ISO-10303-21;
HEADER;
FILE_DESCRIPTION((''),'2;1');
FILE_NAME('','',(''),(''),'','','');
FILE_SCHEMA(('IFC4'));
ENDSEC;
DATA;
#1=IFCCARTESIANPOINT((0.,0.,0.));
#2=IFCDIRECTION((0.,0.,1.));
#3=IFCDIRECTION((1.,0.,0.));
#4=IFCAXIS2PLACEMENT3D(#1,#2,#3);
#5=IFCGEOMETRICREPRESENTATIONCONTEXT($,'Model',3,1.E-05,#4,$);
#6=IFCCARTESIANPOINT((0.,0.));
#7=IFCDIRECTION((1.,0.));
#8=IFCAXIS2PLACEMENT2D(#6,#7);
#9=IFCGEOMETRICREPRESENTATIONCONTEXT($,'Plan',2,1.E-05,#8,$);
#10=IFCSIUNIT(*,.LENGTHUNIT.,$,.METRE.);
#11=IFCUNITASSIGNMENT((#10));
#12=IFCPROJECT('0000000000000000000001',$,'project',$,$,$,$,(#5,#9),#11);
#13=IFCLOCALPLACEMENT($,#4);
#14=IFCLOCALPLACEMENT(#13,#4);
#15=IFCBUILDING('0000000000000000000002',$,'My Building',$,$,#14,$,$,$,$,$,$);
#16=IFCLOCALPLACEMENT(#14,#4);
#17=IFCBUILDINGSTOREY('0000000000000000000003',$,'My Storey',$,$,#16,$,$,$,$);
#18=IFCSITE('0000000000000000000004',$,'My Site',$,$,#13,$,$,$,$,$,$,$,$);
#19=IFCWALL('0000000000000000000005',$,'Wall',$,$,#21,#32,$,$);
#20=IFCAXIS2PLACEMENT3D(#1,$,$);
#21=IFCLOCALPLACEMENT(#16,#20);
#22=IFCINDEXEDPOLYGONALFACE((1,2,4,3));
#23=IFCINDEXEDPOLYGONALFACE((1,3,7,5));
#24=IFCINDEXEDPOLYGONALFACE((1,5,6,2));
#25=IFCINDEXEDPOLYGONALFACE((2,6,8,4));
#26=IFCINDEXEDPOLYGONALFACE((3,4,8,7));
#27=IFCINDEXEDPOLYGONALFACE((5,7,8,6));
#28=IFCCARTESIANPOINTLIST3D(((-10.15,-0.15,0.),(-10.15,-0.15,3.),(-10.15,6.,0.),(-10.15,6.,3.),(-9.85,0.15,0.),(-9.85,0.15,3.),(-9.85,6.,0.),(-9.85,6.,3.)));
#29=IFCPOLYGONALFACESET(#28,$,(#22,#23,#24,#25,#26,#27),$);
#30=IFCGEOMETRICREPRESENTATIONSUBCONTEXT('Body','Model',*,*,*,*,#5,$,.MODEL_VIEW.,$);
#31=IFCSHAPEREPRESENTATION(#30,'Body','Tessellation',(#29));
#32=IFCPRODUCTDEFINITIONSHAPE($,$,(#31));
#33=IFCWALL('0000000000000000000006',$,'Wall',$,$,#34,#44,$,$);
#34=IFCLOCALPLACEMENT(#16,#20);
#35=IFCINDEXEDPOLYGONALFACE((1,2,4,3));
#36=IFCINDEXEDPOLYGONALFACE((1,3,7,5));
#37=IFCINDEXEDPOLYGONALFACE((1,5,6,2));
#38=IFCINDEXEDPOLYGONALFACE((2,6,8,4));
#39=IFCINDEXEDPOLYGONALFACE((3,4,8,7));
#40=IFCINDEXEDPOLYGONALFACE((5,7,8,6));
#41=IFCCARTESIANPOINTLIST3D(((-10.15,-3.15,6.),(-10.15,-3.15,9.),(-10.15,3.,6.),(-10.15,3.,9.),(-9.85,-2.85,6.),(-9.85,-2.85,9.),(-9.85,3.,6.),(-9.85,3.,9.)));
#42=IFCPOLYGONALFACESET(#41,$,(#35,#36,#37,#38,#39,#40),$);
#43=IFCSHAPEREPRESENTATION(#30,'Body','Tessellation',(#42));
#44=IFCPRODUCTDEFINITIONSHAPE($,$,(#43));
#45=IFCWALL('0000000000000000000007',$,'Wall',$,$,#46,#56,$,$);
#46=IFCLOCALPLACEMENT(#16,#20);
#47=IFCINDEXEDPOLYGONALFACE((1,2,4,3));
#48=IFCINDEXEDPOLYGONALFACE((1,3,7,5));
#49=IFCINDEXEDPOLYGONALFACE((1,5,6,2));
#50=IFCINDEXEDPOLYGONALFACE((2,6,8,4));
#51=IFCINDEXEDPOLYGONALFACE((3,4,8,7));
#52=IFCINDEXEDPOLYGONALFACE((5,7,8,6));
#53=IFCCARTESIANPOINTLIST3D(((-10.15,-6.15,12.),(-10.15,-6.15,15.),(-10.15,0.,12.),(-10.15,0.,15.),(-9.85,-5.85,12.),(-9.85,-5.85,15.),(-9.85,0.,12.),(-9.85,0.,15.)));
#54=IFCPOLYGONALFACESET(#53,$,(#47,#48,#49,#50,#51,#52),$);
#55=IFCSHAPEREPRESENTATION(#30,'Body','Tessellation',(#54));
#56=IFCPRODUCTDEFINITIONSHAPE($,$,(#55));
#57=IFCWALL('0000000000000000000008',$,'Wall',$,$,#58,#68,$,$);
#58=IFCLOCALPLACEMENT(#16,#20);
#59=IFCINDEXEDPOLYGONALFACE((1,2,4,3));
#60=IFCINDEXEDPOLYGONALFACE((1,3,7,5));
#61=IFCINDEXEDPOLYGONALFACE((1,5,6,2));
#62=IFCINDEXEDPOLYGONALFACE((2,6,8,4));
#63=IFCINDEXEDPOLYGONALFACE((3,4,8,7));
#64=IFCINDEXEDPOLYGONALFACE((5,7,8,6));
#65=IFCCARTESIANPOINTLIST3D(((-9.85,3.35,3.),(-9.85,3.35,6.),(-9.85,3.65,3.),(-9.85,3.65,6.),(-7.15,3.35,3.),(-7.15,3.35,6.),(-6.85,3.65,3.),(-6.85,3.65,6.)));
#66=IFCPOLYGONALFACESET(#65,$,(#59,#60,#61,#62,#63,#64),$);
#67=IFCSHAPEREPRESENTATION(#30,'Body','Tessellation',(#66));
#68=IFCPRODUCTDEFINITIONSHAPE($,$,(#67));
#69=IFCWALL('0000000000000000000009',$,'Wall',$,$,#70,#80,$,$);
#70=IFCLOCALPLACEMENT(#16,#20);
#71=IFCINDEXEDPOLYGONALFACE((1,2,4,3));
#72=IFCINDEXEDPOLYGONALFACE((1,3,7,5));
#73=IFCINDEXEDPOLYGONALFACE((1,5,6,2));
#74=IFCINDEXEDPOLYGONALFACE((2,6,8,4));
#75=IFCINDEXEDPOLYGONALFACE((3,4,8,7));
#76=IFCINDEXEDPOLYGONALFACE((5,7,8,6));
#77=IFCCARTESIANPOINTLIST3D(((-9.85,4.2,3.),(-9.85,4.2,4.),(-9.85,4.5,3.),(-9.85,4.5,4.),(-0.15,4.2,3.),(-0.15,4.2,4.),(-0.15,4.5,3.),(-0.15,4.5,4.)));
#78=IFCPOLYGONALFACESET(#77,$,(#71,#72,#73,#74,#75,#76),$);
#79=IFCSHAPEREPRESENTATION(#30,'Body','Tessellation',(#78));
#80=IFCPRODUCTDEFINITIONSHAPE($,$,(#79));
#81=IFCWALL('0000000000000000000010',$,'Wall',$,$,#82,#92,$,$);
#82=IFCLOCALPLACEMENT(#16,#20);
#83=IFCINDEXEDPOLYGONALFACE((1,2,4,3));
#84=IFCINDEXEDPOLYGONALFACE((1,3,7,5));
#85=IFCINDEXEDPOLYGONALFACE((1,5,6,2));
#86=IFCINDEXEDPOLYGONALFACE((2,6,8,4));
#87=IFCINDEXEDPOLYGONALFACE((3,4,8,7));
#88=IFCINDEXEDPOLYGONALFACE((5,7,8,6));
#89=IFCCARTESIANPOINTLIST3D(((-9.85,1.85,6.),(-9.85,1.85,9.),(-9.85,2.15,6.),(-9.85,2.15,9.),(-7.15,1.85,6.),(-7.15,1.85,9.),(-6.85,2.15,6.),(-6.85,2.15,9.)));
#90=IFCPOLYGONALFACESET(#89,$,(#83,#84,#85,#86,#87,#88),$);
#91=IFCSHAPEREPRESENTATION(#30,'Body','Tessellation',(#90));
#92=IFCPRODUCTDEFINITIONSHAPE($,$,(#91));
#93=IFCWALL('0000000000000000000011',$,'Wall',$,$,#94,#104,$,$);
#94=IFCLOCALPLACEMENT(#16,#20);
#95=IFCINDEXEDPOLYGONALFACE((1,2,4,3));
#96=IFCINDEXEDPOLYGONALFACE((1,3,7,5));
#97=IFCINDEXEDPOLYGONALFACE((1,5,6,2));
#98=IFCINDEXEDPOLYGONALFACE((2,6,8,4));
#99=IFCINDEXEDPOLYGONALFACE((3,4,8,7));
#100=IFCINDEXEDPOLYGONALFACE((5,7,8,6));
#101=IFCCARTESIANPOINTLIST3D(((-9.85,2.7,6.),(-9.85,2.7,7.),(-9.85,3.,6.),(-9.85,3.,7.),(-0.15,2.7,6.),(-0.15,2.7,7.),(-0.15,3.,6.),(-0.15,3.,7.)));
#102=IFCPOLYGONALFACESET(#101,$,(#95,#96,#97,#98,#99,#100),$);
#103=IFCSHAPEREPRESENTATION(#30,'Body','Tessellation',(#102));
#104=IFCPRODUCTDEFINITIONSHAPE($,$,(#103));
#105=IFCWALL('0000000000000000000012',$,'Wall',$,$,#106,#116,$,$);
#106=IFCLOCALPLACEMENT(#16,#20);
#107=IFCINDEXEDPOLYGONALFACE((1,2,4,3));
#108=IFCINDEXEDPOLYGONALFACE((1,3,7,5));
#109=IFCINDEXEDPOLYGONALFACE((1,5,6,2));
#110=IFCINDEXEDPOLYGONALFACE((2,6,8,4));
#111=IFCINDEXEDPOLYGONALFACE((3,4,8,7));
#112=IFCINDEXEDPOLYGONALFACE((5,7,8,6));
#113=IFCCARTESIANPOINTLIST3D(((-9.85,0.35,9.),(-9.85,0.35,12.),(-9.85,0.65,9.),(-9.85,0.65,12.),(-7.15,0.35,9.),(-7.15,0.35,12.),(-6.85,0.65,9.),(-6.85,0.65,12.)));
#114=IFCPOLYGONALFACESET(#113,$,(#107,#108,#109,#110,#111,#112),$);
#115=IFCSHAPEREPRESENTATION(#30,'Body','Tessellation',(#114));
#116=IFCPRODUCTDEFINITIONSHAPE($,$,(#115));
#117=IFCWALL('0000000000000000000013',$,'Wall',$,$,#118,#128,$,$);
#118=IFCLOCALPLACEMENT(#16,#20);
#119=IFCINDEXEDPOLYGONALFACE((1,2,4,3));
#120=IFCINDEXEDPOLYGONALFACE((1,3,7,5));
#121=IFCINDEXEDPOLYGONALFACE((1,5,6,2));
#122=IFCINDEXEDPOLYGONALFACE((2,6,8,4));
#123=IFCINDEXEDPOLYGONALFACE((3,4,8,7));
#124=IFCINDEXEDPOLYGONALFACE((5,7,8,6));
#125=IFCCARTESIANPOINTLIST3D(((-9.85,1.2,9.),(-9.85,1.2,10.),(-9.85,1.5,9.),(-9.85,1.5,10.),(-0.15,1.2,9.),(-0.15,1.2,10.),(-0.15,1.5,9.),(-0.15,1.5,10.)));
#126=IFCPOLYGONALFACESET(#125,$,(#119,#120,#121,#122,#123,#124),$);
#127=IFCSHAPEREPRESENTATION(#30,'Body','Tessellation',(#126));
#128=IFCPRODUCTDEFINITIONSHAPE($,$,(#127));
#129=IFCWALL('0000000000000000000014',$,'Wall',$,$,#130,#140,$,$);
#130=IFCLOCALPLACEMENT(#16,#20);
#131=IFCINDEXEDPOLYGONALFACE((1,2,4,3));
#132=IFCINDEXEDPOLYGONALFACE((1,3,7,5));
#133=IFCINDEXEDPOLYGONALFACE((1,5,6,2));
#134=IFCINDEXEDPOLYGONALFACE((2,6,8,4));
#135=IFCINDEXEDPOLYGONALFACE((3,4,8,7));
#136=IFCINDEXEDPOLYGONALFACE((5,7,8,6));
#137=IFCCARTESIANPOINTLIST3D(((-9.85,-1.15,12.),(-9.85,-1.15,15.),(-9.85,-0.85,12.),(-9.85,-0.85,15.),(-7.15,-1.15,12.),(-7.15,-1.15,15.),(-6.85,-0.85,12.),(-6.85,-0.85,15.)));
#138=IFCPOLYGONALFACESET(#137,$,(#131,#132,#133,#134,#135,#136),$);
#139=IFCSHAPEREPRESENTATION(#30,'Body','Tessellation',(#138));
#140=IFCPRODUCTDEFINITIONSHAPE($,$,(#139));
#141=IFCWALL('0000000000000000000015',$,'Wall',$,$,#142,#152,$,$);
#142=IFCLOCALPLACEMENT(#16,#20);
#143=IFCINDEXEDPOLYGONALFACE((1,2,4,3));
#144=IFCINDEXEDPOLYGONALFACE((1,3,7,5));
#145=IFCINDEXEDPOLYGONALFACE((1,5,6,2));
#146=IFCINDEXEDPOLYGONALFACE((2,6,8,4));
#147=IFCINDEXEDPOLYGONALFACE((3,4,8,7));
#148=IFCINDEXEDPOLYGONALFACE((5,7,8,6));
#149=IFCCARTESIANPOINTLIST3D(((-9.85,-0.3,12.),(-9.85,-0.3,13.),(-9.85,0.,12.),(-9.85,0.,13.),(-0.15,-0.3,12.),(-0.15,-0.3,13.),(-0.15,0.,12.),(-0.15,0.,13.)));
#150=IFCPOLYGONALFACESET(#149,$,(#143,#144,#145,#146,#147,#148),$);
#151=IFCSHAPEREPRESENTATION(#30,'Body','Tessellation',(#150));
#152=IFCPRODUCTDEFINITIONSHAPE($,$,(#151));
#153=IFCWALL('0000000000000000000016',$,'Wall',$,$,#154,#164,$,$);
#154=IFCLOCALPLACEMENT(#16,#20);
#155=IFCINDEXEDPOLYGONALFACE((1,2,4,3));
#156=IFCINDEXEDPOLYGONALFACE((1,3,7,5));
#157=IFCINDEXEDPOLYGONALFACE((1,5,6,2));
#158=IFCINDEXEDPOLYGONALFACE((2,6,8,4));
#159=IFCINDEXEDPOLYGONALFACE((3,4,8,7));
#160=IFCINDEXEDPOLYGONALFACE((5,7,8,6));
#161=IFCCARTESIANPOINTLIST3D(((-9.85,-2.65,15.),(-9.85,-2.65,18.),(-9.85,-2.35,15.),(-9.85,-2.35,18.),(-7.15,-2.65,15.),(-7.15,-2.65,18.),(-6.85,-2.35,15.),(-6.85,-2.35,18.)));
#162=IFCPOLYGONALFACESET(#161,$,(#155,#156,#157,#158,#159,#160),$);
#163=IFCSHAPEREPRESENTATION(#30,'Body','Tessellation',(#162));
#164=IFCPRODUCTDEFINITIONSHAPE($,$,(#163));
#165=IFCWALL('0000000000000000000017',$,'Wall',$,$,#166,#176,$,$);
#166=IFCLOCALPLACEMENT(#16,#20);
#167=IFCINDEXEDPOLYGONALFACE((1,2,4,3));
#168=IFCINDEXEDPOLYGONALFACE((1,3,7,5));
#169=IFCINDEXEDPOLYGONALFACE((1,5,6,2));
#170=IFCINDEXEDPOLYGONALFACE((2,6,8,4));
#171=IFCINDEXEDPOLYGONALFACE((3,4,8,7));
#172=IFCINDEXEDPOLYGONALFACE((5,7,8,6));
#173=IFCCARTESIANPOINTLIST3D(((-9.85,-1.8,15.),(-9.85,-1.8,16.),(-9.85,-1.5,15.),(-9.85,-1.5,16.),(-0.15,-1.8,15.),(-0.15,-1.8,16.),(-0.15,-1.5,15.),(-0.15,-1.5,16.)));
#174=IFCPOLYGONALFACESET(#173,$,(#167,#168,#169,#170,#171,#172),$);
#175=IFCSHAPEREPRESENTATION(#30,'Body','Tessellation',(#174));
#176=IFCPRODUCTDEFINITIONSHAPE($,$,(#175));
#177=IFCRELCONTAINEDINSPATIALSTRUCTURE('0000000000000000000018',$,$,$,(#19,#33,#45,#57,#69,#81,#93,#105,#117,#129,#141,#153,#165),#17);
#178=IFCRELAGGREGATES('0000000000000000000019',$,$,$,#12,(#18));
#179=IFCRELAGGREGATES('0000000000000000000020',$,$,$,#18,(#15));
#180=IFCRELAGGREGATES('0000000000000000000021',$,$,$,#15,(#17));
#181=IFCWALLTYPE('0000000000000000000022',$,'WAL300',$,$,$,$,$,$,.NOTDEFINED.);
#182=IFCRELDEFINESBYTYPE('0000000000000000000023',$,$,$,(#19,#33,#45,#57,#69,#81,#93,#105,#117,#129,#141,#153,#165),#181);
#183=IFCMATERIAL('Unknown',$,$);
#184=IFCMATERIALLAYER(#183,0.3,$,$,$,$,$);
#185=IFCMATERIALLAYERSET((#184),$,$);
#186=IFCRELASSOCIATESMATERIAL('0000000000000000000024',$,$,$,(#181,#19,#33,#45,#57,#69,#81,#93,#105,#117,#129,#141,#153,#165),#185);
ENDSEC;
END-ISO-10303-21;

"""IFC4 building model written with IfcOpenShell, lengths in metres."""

from ifc_helpers import new_model, si_unit, frame, origin_with_axes, origin_2d_with_axis, place, context, subcontext, project, spatial, line, indexed_curve, outline, extrude, material, layer, layer_set, layer_usage, type_object, element, save


model = new_model("IFC4")

# Units and contexts
model_context = context("Model", 3, precision=1e-05, world=origin_with_axes())
plan_context = context("Plan", 2, precision=1e-05, world=origin_2d_with_axis())
body_context = subcontext(model_context, "Body", "Model", "MODEL_VIEW")
ifc_project = project(units=[si_unit("LENGTHUNIT", "METRE")], contexts=[model_context, plan_context])

# Site, building, storey
site_placement = place(None, origin_with_axes())
site = spatial("IfcSite", under=ifc_project, at=site_placement, Name="My Site")
building_placement = place(site_placement, origin_with_axes())
building = spatial("IfcBuilding", under=site, at=building_placement, Name="My Building")
storey_placement = place(building_placement, origin_with_axes())
storey = spatial("IfcBuildingStorey", under=building, at=storey_placement, Name="My Storey")

# Walls
ifc_material = material(Name="Unknown")
ifc_layer = layer(ifc_material, 0.3)
ifc_layer_set = layer_set([ifc_layer])
wall_type = type_object("IfcWallType", Name="WAL300", PredefinedType="NOTDEFINED", material=ifc_layer_set)
ifc_layer_usage_1 = layer_usage(ifc_layer_set, "AXIS2", "POSITIVE", -0.15)
wall_1_placement = place(storey_placement, frame((-10.0, 0.0, 0.0), z_axis=(0.0, 0.0, 1.0), x_axis=(0.0, 1.0, 0.0)))
element("IfcWall", 1, at=wall_1_placement, inside=storey, type_object=wall_type, material=ifc_layer_usage_1, Name="Wall", context=body_context, shape_type="SweptSolid", body=[
    extrude(outline(indexed_curve([(0.15, -0.15), (-0.15, 0.15), (6.0, 0.15), (6.0, -0.15)], segments=[line(1, 2, 3, 4, 1)])), origin_with_axes(), (0.0, 0.0, 1.0), 3.0),
])
ifc_layer_usage_2 = layer_usage(ifc_layer_set, "AXIS2", "POSITIVE", -0.15)
wall_2_placement = place(storey_placement, frame((-10.0, -3.0, 6.0), z_axis=(0.0, 0.0, 1.0), x_axis=(0.0, 1.0, 0.0)))
element("IfcWall", 2, at=wall_2_placement, inside=storey, type_object=wall_type, material=ifc_layer_usage_2, Name="Wall", context=body_context, shape_type="SweptSolid", body=[
    extrude(outline(indexed_curve([(0.15, -0.15), (-0.15, 0.15), (6.0, 0.15), (6.0, -0.15)], segments=[line(1, 2, 3, 4, 1)])), origin_with_axes(), (0.0, 0.0, 1.0), 3.0),
])
ifc_layer_usage_3 = layer_usage(ifc_layer_set, "AXIS2", "POSITIVE", -0.15)
wall_3_placement = place(storey_placement, frame((-10.0, -6.0, 12.0), z_axis=(0.0, 0.0, 1.0), x_axis=(0.0, 1.0, 0.0)))
element("IfcWall", 3, at=wall_3_placement, inside=storey, type_object=wall_type, material=ifc_layer_usage_3, Name="Wall", context=body_context, shape_type="SweptSolid", body=[
    extrude(outline(indexed_curve([(0.15, -0.15), (-0.15, 0.15), (6.0, 0.15), (6.0, -0.15)], segments=[line(1, 2, 3, 4, 1)])), origin_with_axes(), (0.0, 0.0, 1.0), 3.0),
])
ifc_layer_usage_4 = layer_usage(ifc_layer_set, "AXIS2", "POSITIVE", -0.15)
wall_4_placement = place(storey_placement, frame((-10.0, 3.5, 3.0), z_axis=(0.0, 0.0, 1.0), x_axis=(1.0, 0.0, 0.0)))
element("IfcWall", 4, at=wall_4_placement, inside=storey, type_object=wall_type, material=ifc_layer_usage_4, Name="Wall", context=body_context, shape_type="SweptSolid", body=[
    extrude(outline(indexed_curve([(0.15, -0.15), (0.15, 0.15), (3.15, 0.15), (2.85, -0.15)], segments=[line(1, 2, 3, 4, 1)])), origin_with_axes(), (0.0, 0.0, 1.0), 3.0),
])
ifc_layer_usage_5 = layer_usage(ifc_layer_set, "AXIS2", "POSITIVE", -0.3)
wall_5_placement = place(storey_placement, frame((-9.85, 4.5, 3.0), z_axis=(0.0, 0.0, 1.0), x_axis=(1.0, 0.0, 0.0)))
element("IfcWall", 5, at=wall_5_placement, inside=storey, type_object=wall_type, material=ifc_layer_usage_5, Name="Wall", context=body_context, shape_type="SweptSolid", body=[
    extrude(outline(indexed_curve([(0.0, -0.3), (0.0, 0.0), (9.7, 0.0), (9.7, -0.3)], segments=[line(1, 2, 3, 4, 1)])), origin_with_axes(), (0.0, 0.0, 1.0), 1.0),
])
ifc_layer_usage_6 = layer_usage(ifc_layer_set, "AXIS2", "POSITIVE", -0.15)
wall_6_placement = place(storey_placement, frame((-10.0, 2.0, 6.0), z_axis=(0.0, 0.0, 1.0), x_axis=(1.0, 0.0, 0.0)))
element("IfcWall", 6, at=wall_6_placement, inside=storey, type_object=wall_type, material=ifc_layer_usage_6, Name="Wall", context=body_context, shape_type="SweptSolid", body=[
    extrude(outline(indexed_curve([(0.15, -0.15), (0.15, 0.15), (3.15, 0.15), (2.85, -0.15)], segments=[line(1, 2, 3, 4, 1)])), origin_with_axes(), (0.0, 0.0, 1.0), 3.0),
])
ifc_layer_usage_7 = layer_usage(ifc_layer_set, "AXIS2", "POSITIVE", -0.3)
wall_7_placement = place(storey_placement, frame((-9.85, 3.0, 6.0), z_axis=(0.0, 0.0, 1.0), x_axis=(1.0, 0.0, 0.0)))
element("IfcWall", 7, at=wall_7_placement, inside=storey, type_object=wall_type, material=ifc_layer_usage_7, Name="Wall", context=body_context, shape_type="SweptSolid", body=[
    extrude(outline(indexed_curve([(0.0, -0.3), (0.0, 0.0), (9.7, 0.0), (9.7, -0.3)], segments=[line(1, 2, 3, 4, 1)])), origin_with_axes(), (0.0, 0.0, 1.0), 1.0),
])
ifc_layer_usage_8 = layer_usage(ifc_layer_set, "AXIS2", "POSITIVE", -0.15)
wall_8_placement = place(storey_placement, frame((-10.0, 0.5, 9.0), z_axis=(0.0, 0.0, 1.0), x_axis=(1.0, 0.0, 0.0)))
element("IfcWall", 8, at=wall_8_placement, inside=storey, type_object=wall_type, material=ifc_layer_usage_8, Name="Wall", context=body_context, shape_type="SweptSolid", body=[
    extrude(outline(indexed_curve([(0.15, -0.15), (0.15, 0.15), (3.15, 0.15), (2.85, -0.15)], segments=[line(1, 2, 3, 4, 1)])), origin_with_axes(), (0.0, 0.0, 1.0), 3.0),
])
ifc_layer_usage_9 = layer_usage(ifc_layer_set, "AXIS2", "POSITIVE", -0.3)
wall_9_placement = place(storey_placement, frame((-9.85, 1.5, 9.0), z_axis=(0.0, 0.0, 1.0), x_axis=(1.0, 0.0, 0.0)))
element("IfcWall", 9, at=wall_9_placement, inside=storey, type_object=wall_type, material=ifc_layer_usage_9, Name="Wall", context=body_context, shape_type="SweptSolid", body=[
    extrude(outline(indexed_curve([(0.0, -0.3), (0.0, 0.0), (9.7, 0.0), (9.7, -0.3)], segments=[line(1, 2, 3, 4, 1)])), origin_with_axes(), (0.0, 0.0, 1.0), 1.0),
])
ifc_layer_usage_10 = layer_usage(ifc_layer_set, "AXIS2", "POSITIVE", -0.15)
wall_10_placement = place(storey_placement, frame((-10.0, -1.0, 12.0), z_axis=(0.0, 0.0, 1.0), x_axis=(1.0, 0.0, 0.0)))
element("IfcWall", 10, at=wall_10_placement, inside=storey, type_object=wall_type, material=ifc_layer_usage_10, Name="Wall", context=body_context, shape_type="SweptSolid", body=[
    extrude(outline(indexed_curve([(0.15, -0.15), (0.15, 0.15), (3.15, 0.15), (2.85, -0.15)], segments=[line(1, 2, 3, 4, 1)])), origin_with_axes(), (0.0, 0.0, 1.0), 3.0),
])
ifc_layer_usage_11 = layer_usage(ifc_layer_set, "AXIS2", "POSITIVE", -0.3)
wall_11_placement = place(storey_placement, frame((-9.85, 0.0, 12.0), z_axis=(0.0, 0.0, 1.0), x_axis=(1.0, 0.0, 0.0)))
element("IfcWall", 11, at=wall_11_placement, inside=storey, type_object=wall_type, material=ifc_layer_usage_11, Name="Wall", context=body_context, shape_type="SweptSolid", body=[
    extrude(outline(indexed_curve([(0.0, -0.3), (0.0, 0.0), (9.7, 0.0), (9.7, -0.3)], segments=[line(1, 2, 3, 4, 1)])), origin_with_axes(), (0.0, 0.0, 1.0), 1.0),
])
ifc_layer_usage_12 = layer_usage(ifc_layer_set, "AXIS2", "POSITIVE", -0.15)
wall_12_placement = place(storey_placement, frame((-10.0, -2.5, 15.0), z_axis=(0.0, 0.0, 1.0), x_axis=(1.0, 0.0, 0.0)))
element("IfcWall", 12, at=wall_12_placement, inside=storey, type_object=wall_type, material=ifc_layer_usage_12, Name="Wall", context=body_context, shape_type="SweptSolid", body=[
    extrude(outline(indexed_curve([(0.15, -0.15), (0.15, 0.15), (3.15, 0.15), (2.85, -0.15)], segments=[line(1, 2, 3, 4, 1)])), origin_with_axes(), (0.0, 0.0, 1.0), 3.0),
])
ifc_layer_usage_13 = layer_usage(ifc_layer_set, "AXIS2", "POSITIVE", -0.3)
wall_13_placement = place(storey_placement, frame((-9.85, -1.5, 15.0), z_axis=(0.0, 0.0, 1.0), x_axis=(1.0, 0.0, 0.0)))
element("IfcWall", 13, at=wall_13_placement, inside=storey, type_object=wall_type, material=ifc_layer_usage_13, Name="Wall", context=body_context, shape_type="SweptSolid", body=[
    extrude(outline(indexed_curve([(0.0, -0.3), (0.0, 0.0), (9.7, 0.0), (9.7, -0.3)], segments=[line(1, 2, 3, 4, 1)])), origin_with_axes(), (0.0, 0.0, 1.0), 1.0),
])

save(model, "model.ifc")
